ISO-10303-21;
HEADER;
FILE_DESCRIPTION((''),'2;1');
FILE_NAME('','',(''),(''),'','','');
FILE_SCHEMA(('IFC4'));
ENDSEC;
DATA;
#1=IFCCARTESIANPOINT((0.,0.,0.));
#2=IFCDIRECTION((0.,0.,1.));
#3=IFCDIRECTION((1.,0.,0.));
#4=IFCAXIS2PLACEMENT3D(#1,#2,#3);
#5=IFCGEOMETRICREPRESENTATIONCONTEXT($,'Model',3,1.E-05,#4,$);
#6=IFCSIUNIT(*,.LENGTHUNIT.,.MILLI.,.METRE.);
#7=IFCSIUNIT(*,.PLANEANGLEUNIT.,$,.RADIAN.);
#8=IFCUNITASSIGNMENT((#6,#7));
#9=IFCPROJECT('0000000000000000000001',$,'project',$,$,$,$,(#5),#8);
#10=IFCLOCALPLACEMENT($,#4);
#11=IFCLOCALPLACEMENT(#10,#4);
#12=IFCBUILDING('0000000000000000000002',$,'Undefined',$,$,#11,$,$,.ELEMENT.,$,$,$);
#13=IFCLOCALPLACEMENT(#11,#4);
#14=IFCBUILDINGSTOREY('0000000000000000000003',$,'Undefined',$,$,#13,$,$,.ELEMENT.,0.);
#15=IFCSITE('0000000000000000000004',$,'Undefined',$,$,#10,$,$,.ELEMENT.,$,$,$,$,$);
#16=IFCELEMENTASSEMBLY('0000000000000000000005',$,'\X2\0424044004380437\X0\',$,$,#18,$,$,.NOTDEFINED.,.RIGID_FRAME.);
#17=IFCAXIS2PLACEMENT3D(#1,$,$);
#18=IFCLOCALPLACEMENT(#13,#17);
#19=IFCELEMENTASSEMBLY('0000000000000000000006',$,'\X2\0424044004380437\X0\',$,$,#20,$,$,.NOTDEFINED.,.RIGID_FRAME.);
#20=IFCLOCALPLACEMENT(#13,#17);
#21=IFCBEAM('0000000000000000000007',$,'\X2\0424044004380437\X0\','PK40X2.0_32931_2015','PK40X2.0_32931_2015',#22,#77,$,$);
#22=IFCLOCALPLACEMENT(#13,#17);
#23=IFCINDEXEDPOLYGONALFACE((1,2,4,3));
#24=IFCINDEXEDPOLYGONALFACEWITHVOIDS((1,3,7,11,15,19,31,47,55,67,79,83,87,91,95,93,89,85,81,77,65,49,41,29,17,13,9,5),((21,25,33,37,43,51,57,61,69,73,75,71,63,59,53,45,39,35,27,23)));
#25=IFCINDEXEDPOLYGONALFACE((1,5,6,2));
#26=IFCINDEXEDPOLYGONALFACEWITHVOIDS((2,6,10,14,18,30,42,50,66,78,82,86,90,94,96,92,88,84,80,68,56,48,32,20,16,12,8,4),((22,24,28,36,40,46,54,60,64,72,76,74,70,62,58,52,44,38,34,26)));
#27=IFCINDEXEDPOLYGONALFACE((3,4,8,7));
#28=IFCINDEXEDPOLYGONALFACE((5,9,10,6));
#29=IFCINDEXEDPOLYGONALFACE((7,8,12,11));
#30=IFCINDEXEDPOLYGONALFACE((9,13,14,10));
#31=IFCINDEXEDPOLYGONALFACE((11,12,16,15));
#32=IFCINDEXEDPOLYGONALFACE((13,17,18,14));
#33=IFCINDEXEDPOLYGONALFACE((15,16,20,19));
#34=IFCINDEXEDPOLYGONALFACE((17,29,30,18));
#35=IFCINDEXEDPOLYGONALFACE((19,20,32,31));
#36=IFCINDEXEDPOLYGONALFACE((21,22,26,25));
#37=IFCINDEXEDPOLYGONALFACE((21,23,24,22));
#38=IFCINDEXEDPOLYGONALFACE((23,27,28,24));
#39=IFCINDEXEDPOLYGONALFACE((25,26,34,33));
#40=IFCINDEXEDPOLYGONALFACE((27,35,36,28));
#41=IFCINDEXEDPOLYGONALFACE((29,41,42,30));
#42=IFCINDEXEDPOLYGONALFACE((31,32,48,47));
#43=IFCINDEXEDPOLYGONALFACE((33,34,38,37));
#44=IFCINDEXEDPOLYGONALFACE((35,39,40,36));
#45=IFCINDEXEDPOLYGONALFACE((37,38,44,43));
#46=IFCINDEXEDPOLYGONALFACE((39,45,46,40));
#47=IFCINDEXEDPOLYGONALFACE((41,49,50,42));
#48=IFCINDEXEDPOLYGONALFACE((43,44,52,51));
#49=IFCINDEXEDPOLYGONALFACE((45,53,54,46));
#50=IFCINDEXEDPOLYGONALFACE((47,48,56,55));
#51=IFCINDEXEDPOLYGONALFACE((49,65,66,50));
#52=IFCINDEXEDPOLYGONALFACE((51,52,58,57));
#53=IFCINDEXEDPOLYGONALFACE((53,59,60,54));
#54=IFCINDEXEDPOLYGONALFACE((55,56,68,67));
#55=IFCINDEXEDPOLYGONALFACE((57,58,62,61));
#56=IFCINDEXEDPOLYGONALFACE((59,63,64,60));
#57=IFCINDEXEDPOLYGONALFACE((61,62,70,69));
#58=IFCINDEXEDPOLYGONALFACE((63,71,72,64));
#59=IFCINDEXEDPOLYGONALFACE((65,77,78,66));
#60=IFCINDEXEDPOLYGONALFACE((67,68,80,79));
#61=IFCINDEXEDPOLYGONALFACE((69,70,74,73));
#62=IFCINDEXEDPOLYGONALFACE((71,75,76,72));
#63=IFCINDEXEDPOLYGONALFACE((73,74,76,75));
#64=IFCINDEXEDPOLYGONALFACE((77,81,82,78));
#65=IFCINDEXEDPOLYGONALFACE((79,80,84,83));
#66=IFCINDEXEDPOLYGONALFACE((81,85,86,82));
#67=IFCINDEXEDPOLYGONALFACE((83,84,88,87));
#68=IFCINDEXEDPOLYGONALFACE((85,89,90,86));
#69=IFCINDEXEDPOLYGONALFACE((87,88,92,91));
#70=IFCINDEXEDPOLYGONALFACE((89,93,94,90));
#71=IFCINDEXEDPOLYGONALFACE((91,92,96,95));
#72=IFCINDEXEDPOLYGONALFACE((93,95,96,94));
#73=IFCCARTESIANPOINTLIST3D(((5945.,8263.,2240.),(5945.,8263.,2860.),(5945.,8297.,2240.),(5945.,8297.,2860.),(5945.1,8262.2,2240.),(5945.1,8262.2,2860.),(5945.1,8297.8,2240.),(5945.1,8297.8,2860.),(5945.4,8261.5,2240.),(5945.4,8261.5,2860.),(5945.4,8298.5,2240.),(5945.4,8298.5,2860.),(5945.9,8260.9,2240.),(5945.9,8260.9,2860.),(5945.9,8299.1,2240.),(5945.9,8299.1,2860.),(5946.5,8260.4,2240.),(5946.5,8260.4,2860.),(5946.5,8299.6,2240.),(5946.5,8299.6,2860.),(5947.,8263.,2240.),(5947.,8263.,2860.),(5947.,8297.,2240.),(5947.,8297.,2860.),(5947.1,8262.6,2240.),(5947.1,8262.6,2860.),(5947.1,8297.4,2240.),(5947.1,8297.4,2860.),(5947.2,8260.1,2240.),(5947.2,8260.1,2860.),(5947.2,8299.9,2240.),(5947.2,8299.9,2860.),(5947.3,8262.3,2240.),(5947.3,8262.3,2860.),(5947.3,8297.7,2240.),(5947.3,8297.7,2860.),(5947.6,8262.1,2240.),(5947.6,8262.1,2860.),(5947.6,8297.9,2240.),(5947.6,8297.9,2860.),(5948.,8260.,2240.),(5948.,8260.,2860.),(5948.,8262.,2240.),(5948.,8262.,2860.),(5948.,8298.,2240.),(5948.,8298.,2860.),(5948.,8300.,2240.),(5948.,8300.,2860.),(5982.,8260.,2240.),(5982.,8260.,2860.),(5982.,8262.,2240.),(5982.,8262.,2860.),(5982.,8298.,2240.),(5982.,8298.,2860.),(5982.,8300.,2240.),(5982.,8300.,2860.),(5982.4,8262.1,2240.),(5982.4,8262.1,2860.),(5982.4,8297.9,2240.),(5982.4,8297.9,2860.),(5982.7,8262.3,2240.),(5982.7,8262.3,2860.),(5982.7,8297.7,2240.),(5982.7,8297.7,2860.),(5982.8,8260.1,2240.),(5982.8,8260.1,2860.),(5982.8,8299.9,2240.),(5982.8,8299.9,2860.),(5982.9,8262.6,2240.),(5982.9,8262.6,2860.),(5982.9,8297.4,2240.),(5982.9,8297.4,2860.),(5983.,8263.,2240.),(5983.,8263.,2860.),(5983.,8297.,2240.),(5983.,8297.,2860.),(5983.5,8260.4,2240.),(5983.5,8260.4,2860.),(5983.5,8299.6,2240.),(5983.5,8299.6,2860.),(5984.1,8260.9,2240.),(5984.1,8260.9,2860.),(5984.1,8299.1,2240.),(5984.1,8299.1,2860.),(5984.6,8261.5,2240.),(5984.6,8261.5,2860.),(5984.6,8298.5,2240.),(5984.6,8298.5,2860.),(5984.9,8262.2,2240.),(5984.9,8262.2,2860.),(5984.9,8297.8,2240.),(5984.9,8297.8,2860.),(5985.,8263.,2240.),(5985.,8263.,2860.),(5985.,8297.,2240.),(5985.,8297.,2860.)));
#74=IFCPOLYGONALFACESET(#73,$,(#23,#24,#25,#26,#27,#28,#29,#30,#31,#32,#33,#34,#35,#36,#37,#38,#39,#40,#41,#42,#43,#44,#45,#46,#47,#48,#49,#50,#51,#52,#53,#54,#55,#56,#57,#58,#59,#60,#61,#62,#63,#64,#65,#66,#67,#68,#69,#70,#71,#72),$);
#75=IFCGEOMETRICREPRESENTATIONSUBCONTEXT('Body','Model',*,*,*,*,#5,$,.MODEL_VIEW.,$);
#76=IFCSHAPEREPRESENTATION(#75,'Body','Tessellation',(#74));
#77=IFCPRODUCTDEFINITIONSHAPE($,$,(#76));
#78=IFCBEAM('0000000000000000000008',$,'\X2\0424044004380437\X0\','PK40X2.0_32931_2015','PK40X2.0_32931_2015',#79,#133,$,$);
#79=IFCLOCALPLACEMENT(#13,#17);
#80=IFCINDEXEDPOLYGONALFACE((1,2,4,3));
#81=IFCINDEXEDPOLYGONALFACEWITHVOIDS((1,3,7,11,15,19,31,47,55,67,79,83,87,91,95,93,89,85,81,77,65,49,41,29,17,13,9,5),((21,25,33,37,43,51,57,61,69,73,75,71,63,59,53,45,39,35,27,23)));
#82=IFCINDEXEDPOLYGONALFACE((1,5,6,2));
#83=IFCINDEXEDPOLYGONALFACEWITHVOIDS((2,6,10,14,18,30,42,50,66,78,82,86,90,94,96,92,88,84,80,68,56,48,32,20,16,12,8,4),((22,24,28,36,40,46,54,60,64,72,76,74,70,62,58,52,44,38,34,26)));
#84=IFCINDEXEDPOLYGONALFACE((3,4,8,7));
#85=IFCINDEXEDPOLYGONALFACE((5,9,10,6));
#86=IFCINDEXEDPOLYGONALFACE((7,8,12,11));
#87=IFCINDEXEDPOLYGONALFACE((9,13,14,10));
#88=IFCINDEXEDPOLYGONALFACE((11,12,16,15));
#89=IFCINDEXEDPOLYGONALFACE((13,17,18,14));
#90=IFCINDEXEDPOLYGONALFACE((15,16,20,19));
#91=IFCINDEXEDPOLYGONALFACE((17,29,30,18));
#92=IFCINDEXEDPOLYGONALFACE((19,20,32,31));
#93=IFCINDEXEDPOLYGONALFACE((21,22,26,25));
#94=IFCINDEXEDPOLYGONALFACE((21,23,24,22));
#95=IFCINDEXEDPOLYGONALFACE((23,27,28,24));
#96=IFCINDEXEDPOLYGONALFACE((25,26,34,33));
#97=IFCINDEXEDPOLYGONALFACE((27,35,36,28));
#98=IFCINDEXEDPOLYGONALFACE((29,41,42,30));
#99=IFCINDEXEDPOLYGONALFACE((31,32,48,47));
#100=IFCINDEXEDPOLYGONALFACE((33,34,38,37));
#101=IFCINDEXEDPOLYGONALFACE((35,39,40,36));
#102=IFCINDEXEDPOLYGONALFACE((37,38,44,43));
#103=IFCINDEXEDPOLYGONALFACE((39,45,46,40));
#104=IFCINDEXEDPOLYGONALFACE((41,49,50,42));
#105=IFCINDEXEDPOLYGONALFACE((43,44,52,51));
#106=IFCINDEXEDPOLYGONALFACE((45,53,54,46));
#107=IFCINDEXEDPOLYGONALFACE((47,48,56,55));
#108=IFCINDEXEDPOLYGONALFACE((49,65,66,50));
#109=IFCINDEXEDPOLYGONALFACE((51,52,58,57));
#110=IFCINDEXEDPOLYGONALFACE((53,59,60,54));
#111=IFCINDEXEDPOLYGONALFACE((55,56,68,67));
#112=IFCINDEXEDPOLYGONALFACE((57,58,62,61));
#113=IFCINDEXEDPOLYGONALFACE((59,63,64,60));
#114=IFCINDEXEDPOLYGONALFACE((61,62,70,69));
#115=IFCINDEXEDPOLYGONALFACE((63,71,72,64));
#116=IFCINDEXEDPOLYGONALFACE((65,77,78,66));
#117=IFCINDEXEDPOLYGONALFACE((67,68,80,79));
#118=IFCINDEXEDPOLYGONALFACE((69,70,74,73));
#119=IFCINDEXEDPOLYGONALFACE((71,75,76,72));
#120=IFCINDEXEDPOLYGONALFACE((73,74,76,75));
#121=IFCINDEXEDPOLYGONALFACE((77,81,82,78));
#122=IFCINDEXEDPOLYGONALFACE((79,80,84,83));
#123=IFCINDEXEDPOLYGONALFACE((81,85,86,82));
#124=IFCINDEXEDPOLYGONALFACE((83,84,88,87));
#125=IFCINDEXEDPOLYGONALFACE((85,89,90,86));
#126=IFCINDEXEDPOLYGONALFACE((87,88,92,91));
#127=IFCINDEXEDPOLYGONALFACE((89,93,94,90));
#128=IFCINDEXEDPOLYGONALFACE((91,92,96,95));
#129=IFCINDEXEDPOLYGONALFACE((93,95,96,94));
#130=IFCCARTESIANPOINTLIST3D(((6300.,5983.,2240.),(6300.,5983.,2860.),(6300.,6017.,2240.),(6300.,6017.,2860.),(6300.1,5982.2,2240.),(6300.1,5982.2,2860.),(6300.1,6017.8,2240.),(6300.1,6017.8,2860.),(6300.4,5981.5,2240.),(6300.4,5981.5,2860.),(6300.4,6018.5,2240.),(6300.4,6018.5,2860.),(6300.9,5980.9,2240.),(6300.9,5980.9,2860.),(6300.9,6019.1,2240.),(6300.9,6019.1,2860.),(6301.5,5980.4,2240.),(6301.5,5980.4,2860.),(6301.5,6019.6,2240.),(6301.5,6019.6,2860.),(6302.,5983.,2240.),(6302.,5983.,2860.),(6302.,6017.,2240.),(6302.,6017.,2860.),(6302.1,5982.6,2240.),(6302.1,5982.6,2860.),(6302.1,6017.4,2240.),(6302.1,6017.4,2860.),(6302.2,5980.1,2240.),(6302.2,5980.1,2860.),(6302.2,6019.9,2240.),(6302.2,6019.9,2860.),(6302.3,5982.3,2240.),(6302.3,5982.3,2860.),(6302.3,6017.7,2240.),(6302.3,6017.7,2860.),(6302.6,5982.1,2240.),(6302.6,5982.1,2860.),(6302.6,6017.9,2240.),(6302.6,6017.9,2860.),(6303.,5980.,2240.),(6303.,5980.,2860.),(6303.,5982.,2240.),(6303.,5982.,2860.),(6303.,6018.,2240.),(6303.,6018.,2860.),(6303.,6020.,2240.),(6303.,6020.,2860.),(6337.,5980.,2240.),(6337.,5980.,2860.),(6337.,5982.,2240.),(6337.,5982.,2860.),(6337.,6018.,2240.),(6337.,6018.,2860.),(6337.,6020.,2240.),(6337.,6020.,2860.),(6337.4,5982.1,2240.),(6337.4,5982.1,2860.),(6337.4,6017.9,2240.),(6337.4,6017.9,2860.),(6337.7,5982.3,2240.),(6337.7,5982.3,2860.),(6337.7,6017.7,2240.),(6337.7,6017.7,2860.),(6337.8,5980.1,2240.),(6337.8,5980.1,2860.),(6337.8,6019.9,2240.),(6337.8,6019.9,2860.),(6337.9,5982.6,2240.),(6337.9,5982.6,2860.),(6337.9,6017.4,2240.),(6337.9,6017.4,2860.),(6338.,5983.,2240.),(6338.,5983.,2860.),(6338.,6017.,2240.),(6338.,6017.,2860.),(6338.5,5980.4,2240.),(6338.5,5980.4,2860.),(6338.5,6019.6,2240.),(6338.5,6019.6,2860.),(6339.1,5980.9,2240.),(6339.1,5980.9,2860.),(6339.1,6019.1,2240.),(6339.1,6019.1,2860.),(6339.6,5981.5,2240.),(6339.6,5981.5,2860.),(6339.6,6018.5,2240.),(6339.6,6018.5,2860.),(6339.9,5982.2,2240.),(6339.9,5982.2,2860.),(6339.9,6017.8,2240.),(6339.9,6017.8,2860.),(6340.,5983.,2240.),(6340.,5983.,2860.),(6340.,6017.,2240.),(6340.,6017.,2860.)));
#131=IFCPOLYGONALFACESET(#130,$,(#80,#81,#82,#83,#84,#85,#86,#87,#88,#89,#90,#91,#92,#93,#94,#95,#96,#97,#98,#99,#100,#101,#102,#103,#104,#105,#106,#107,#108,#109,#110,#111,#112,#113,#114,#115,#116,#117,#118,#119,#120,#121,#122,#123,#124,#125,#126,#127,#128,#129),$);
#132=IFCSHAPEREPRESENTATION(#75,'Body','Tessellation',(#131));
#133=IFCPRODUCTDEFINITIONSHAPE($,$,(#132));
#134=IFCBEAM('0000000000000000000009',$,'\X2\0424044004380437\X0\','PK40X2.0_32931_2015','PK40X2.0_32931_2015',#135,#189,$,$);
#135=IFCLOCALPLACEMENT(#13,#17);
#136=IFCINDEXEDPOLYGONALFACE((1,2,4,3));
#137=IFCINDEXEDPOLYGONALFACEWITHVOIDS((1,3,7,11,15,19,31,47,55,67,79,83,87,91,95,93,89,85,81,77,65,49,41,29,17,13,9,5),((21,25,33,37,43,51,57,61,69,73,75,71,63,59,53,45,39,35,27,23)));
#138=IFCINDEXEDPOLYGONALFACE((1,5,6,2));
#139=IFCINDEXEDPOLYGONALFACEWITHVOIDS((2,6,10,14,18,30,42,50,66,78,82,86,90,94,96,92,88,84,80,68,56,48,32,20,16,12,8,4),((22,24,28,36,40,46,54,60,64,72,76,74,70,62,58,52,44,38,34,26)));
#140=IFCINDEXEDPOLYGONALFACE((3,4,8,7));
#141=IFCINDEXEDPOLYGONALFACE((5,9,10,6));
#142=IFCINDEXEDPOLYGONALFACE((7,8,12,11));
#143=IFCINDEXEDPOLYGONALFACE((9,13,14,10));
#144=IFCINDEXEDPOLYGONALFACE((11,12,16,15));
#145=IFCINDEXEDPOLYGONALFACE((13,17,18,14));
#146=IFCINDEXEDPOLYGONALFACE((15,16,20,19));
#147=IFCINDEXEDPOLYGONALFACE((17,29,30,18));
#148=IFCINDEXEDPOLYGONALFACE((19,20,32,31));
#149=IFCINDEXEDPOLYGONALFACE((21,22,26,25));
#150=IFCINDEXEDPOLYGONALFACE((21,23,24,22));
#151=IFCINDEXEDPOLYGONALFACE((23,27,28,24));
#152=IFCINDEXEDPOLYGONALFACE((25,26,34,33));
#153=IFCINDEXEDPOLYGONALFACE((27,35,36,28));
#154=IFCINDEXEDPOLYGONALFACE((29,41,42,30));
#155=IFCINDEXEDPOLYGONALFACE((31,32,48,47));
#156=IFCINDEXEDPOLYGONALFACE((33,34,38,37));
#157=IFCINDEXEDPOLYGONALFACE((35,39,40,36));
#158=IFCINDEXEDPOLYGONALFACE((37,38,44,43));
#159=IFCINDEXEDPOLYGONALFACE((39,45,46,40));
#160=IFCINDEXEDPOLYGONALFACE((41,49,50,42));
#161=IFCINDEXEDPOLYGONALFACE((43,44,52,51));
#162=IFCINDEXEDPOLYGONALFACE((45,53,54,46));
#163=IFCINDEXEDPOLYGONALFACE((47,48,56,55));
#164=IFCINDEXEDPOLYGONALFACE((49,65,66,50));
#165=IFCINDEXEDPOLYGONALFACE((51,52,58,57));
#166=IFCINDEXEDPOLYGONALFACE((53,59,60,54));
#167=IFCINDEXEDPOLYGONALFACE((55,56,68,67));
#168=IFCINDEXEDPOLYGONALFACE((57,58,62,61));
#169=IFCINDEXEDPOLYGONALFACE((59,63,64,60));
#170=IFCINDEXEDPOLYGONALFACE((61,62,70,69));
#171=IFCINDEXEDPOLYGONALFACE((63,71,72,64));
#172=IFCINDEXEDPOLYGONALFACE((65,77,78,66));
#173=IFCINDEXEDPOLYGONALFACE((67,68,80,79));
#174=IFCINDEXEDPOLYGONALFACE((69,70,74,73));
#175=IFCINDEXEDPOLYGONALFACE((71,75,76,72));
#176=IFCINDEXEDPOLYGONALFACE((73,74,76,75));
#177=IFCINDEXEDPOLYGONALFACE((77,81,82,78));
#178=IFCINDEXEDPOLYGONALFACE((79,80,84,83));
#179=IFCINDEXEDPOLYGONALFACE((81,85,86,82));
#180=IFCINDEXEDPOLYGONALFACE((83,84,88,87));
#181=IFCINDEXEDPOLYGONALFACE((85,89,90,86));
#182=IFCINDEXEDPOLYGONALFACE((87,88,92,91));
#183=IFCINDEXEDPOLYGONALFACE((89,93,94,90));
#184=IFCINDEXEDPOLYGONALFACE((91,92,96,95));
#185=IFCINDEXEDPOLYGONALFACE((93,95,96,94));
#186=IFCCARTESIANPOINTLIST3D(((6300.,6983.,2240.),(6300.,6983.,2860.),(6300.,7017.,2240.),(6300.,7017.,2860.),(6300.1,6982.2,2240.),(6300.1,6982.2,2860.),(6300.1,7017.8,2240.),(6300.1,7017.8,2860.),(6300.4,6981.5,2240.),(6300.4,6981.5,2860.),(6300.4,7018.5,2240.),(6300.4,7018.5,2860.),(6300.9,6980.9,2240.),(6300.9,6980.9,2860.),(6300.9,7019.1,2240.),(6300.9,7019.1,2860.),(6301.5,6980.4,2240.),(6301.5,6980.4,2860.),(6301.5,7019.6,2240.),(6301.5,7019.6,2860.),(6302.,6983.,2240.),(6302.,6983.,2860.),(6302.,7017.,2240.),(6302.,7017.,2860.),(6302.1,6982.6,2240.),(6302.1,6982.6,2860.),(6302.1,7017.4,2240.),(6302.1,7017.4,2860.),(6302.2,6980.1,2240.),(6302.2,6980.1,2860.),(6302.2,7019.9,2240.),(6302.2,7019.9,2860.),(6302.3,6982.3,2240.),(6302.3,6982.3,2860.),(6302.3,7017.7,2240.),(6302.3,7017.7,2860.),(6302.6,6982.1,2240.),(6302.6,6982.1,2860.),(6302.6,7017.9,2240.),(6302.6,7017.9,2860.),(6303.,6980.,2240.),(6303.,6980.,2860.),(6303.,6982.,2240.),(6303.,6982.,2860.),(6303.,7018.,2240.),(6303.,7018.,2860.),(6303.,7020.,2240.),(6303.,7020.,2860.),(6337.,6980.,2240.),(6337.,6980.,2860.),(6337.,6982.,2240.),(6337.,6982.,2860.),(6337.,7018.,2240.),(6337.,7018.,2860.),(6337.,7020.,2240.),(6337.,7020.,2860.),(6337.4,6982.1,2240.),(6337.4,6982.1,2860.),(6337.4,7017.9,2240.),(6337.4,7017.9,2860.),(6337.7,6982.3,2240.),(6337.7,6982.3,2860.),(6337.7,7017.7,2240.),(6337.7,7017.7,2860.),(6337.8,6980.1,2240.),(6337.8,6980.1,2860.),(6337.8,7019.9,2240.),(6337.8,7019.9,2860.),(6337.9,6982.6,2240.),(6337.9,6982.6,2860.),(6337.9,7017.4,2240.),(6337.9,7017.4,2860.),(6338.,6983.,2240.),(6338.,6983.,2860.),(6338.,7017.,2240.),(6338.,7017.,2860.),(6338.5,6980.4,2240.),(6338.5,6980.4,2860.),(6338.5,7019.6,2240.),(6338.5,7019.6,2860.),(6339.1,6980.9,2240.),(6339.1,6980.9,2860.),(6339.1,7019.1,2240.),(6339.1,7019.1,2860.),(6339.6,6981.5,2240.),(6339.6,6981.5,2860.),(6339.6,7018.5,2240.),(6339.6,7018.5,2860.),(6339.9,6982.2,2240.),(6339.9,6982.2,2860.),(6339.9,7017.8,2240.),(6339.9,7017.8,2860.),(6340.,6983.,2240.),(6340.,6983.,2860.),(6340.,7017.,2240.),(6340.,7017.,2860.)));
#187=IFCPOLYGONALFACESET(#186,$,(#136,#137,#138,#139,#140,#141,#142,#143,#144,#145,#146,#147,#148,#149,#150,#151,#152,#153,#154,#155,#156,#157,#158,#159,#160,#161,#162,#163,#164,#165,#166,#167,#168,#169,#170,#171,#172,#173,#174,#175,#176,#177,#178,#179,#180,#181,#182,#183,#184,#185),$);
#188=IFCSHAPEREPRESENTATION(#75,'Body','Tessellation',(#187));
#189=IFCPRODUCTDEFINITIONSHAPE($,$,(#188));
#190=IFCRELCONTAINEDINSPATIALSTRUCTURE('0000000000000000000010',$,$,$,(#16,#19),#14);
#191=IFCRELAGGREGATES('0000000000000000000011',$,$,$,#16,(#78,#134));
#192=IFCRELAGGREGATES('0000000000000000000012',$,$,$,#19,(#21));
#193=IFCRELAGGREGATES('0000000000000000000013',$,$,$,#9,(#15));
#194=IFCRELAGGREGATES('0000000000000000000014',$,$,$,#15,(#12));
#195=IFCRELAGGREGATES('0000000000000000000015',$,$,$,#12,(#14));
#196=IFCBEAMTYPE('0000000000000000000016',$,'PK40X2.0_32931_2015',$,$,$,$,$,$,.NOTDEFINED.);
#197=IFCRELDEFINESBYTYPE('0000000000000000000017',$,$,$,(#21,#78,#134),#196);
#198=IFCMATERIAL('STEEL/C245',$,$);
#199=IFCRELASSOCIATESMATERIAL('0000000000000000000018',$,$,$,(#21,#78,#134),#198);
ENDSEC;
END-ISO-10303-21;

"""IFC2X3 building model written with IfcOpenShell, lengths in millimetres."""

from ifc_helpers import new_model, si_unit, frame, origin_with_axes, origin_2d_with_axis, place, context, subcontext, project, spatial, hollow_rectangle, extrude, material, type_object, element, aggregate, save


model = new_model("IFC2X3")

# Units and contexts
model_context = context("Model", 3, precision=1e-05, world=origin_with_axes())
body_context = subcontext(model_context, "Body", "Model", "MODEL_VIEW")
ifc_project = project(units=[si_unit("LENGTHUNIT", "METRE", prefix="MILLI"), si_unit("PLANEANGLEUNIT", "RADIAN")], contexts=[model_context])

# Site, building, storey
site_placement = place(None, origin_with_axes())
site = spatial("IfcSite", under=ifc_project, at=site_placement, Name="Undefined", CompositionType="ELEMENT")
building_placement = place(site_placement, origin_with_axes())
building = spatial("IfcBuilding", under=site, at=building_placement, Name="Undefined", CompositionType="ELEMENT")
storey_placement = place(building_placement, origin_with_axes())
storey = spatial("IfcBuildingStorey", under=building, at=storey_placement, Name="Undefined", CompositionType="ELEMENT", Elevation=0.0)

# Shared definitions
ifc_material_1 = material(Name="STEEL/C245")

# Element assembly
assembly_1_placement = place(storey_placement, origin_with_axes())
assembly_1 = element("IfcElementAssembly", 1, at=assembly_1_placement, inside=storey, Name="Фриз", AssemblyPlace="NOTDEFINED", PredefinedType="RIGID_FRAME")

# Shared definitions
beam_type_1 = type_object("IfcBeamType", Name="PK40X2.0_32931_2015", PredefinedType="NOTDEFINED")

# Element assembly, beam
assembly_2_placement = place(storey_placement, origin_with_axes())
assembly_2 = element("IfcElementAssembly", 2, at=assembly_2_placement, inside=storey, Name="Фриз", AssemblyPlace="NOTDEFINED", PredefinedType="RIGID_FRAME")
beam_1_placement = place(assembly_2_placement, frame((5965.0, 8280.0, 2860.0), z_axis=(1.0, 0.0, 0.0), x_axis=(0.0, 0.0, -1.0)))
beam_1 = element("IfcBeam", 3, at=beam_1_placement, type_object=beam_type_1, material=ifc_material_1, Name="Фриз", Description="PK40X2.0_32931_2015", ObjectType="PK40X2.0_32931_2015", context=body_context, shape_type="SweptSolid", body=[
    extrude(hollow_rectangle(XDim=40.0, YDim=40.0, WallThickness=2.0, InnerFilletRadius=1.0, OuterFilletRadius=3.0, at=origin_2d_with_axis()), frame((620.0, 0.0, 0.0), z_axis=(-1.0, 0.0, 0.0), x_axis=(0.0, -1.0, 0.0)), (0.0, 0.0, 1.0), 620.0),
])

# Beams
beam_2_placement = place(assembly_1_placement, frame((6320.0, 6000.0, 2860.0), z_axis=(-1.0, 0.0, 0.0), x_axis=(0.0, 0.0, -1.0)))
beam_2 = element("IfcBeam", 4, at=beam_2_placement, type_object=beam_type_1, material=ifc_material_1, Name="Фриз", Description="PK40X2.0_32931_2015", ObjectType="PK40X2.0_32931_2015", context=body_context, shape_type="SweptSolid", body=[
    extrude(hollow_rectangle(XDim=40.0, YDim=40.0, WallThickness=2.0, InnerFilletRadius=1.0, OuterFilletRadius=3.0, at=origin_2d_with_axis()), frame((620.0, 0.0, 0.0), z_axis=(-1.0, 0.0, 0.0), x_axis=(0.0, -1.0, 0.0)), (0.0, 0.0, 1.0), 620.0),
])
beam_3_placement = place(assembly_1_placement, frame((6320.0, 7000.0, 2860.0), z_axis=(-1.0, 0.0, 0.0), x_axis=(0.0, 0.0, -1.0)))
beam_3 = element("IfcBeam", 5, at=beam_3_placement, type_object=beam_type_1, material=ifc_material_1, Name="Фриз", Description="PK40X2.0_32931_2015", ObjectType="PK40X2.0_32931_2015", context=body_context, shape_type="SweptSolid", body=[
    extrude(hollow_rectangle(XDim=40.0, YDim=40.0, WallThickness=2.0, InnerFilletRadius=1.0, OuterFilletRadius=3.0, at=origin_2d_with_axis()), frame((620.0, 0.0, 0.0), z_axis=(-1.0, 0.0, 0.0), x_axis=(0.0, -1.0, 0.0)), (0.0, 0.0, 1.0), 620.0),
])
aggregate(assembly_1, [beam_2, beam_3])
aggregate(assembly_2, [beam_1])

save(model, "model.ifc")
